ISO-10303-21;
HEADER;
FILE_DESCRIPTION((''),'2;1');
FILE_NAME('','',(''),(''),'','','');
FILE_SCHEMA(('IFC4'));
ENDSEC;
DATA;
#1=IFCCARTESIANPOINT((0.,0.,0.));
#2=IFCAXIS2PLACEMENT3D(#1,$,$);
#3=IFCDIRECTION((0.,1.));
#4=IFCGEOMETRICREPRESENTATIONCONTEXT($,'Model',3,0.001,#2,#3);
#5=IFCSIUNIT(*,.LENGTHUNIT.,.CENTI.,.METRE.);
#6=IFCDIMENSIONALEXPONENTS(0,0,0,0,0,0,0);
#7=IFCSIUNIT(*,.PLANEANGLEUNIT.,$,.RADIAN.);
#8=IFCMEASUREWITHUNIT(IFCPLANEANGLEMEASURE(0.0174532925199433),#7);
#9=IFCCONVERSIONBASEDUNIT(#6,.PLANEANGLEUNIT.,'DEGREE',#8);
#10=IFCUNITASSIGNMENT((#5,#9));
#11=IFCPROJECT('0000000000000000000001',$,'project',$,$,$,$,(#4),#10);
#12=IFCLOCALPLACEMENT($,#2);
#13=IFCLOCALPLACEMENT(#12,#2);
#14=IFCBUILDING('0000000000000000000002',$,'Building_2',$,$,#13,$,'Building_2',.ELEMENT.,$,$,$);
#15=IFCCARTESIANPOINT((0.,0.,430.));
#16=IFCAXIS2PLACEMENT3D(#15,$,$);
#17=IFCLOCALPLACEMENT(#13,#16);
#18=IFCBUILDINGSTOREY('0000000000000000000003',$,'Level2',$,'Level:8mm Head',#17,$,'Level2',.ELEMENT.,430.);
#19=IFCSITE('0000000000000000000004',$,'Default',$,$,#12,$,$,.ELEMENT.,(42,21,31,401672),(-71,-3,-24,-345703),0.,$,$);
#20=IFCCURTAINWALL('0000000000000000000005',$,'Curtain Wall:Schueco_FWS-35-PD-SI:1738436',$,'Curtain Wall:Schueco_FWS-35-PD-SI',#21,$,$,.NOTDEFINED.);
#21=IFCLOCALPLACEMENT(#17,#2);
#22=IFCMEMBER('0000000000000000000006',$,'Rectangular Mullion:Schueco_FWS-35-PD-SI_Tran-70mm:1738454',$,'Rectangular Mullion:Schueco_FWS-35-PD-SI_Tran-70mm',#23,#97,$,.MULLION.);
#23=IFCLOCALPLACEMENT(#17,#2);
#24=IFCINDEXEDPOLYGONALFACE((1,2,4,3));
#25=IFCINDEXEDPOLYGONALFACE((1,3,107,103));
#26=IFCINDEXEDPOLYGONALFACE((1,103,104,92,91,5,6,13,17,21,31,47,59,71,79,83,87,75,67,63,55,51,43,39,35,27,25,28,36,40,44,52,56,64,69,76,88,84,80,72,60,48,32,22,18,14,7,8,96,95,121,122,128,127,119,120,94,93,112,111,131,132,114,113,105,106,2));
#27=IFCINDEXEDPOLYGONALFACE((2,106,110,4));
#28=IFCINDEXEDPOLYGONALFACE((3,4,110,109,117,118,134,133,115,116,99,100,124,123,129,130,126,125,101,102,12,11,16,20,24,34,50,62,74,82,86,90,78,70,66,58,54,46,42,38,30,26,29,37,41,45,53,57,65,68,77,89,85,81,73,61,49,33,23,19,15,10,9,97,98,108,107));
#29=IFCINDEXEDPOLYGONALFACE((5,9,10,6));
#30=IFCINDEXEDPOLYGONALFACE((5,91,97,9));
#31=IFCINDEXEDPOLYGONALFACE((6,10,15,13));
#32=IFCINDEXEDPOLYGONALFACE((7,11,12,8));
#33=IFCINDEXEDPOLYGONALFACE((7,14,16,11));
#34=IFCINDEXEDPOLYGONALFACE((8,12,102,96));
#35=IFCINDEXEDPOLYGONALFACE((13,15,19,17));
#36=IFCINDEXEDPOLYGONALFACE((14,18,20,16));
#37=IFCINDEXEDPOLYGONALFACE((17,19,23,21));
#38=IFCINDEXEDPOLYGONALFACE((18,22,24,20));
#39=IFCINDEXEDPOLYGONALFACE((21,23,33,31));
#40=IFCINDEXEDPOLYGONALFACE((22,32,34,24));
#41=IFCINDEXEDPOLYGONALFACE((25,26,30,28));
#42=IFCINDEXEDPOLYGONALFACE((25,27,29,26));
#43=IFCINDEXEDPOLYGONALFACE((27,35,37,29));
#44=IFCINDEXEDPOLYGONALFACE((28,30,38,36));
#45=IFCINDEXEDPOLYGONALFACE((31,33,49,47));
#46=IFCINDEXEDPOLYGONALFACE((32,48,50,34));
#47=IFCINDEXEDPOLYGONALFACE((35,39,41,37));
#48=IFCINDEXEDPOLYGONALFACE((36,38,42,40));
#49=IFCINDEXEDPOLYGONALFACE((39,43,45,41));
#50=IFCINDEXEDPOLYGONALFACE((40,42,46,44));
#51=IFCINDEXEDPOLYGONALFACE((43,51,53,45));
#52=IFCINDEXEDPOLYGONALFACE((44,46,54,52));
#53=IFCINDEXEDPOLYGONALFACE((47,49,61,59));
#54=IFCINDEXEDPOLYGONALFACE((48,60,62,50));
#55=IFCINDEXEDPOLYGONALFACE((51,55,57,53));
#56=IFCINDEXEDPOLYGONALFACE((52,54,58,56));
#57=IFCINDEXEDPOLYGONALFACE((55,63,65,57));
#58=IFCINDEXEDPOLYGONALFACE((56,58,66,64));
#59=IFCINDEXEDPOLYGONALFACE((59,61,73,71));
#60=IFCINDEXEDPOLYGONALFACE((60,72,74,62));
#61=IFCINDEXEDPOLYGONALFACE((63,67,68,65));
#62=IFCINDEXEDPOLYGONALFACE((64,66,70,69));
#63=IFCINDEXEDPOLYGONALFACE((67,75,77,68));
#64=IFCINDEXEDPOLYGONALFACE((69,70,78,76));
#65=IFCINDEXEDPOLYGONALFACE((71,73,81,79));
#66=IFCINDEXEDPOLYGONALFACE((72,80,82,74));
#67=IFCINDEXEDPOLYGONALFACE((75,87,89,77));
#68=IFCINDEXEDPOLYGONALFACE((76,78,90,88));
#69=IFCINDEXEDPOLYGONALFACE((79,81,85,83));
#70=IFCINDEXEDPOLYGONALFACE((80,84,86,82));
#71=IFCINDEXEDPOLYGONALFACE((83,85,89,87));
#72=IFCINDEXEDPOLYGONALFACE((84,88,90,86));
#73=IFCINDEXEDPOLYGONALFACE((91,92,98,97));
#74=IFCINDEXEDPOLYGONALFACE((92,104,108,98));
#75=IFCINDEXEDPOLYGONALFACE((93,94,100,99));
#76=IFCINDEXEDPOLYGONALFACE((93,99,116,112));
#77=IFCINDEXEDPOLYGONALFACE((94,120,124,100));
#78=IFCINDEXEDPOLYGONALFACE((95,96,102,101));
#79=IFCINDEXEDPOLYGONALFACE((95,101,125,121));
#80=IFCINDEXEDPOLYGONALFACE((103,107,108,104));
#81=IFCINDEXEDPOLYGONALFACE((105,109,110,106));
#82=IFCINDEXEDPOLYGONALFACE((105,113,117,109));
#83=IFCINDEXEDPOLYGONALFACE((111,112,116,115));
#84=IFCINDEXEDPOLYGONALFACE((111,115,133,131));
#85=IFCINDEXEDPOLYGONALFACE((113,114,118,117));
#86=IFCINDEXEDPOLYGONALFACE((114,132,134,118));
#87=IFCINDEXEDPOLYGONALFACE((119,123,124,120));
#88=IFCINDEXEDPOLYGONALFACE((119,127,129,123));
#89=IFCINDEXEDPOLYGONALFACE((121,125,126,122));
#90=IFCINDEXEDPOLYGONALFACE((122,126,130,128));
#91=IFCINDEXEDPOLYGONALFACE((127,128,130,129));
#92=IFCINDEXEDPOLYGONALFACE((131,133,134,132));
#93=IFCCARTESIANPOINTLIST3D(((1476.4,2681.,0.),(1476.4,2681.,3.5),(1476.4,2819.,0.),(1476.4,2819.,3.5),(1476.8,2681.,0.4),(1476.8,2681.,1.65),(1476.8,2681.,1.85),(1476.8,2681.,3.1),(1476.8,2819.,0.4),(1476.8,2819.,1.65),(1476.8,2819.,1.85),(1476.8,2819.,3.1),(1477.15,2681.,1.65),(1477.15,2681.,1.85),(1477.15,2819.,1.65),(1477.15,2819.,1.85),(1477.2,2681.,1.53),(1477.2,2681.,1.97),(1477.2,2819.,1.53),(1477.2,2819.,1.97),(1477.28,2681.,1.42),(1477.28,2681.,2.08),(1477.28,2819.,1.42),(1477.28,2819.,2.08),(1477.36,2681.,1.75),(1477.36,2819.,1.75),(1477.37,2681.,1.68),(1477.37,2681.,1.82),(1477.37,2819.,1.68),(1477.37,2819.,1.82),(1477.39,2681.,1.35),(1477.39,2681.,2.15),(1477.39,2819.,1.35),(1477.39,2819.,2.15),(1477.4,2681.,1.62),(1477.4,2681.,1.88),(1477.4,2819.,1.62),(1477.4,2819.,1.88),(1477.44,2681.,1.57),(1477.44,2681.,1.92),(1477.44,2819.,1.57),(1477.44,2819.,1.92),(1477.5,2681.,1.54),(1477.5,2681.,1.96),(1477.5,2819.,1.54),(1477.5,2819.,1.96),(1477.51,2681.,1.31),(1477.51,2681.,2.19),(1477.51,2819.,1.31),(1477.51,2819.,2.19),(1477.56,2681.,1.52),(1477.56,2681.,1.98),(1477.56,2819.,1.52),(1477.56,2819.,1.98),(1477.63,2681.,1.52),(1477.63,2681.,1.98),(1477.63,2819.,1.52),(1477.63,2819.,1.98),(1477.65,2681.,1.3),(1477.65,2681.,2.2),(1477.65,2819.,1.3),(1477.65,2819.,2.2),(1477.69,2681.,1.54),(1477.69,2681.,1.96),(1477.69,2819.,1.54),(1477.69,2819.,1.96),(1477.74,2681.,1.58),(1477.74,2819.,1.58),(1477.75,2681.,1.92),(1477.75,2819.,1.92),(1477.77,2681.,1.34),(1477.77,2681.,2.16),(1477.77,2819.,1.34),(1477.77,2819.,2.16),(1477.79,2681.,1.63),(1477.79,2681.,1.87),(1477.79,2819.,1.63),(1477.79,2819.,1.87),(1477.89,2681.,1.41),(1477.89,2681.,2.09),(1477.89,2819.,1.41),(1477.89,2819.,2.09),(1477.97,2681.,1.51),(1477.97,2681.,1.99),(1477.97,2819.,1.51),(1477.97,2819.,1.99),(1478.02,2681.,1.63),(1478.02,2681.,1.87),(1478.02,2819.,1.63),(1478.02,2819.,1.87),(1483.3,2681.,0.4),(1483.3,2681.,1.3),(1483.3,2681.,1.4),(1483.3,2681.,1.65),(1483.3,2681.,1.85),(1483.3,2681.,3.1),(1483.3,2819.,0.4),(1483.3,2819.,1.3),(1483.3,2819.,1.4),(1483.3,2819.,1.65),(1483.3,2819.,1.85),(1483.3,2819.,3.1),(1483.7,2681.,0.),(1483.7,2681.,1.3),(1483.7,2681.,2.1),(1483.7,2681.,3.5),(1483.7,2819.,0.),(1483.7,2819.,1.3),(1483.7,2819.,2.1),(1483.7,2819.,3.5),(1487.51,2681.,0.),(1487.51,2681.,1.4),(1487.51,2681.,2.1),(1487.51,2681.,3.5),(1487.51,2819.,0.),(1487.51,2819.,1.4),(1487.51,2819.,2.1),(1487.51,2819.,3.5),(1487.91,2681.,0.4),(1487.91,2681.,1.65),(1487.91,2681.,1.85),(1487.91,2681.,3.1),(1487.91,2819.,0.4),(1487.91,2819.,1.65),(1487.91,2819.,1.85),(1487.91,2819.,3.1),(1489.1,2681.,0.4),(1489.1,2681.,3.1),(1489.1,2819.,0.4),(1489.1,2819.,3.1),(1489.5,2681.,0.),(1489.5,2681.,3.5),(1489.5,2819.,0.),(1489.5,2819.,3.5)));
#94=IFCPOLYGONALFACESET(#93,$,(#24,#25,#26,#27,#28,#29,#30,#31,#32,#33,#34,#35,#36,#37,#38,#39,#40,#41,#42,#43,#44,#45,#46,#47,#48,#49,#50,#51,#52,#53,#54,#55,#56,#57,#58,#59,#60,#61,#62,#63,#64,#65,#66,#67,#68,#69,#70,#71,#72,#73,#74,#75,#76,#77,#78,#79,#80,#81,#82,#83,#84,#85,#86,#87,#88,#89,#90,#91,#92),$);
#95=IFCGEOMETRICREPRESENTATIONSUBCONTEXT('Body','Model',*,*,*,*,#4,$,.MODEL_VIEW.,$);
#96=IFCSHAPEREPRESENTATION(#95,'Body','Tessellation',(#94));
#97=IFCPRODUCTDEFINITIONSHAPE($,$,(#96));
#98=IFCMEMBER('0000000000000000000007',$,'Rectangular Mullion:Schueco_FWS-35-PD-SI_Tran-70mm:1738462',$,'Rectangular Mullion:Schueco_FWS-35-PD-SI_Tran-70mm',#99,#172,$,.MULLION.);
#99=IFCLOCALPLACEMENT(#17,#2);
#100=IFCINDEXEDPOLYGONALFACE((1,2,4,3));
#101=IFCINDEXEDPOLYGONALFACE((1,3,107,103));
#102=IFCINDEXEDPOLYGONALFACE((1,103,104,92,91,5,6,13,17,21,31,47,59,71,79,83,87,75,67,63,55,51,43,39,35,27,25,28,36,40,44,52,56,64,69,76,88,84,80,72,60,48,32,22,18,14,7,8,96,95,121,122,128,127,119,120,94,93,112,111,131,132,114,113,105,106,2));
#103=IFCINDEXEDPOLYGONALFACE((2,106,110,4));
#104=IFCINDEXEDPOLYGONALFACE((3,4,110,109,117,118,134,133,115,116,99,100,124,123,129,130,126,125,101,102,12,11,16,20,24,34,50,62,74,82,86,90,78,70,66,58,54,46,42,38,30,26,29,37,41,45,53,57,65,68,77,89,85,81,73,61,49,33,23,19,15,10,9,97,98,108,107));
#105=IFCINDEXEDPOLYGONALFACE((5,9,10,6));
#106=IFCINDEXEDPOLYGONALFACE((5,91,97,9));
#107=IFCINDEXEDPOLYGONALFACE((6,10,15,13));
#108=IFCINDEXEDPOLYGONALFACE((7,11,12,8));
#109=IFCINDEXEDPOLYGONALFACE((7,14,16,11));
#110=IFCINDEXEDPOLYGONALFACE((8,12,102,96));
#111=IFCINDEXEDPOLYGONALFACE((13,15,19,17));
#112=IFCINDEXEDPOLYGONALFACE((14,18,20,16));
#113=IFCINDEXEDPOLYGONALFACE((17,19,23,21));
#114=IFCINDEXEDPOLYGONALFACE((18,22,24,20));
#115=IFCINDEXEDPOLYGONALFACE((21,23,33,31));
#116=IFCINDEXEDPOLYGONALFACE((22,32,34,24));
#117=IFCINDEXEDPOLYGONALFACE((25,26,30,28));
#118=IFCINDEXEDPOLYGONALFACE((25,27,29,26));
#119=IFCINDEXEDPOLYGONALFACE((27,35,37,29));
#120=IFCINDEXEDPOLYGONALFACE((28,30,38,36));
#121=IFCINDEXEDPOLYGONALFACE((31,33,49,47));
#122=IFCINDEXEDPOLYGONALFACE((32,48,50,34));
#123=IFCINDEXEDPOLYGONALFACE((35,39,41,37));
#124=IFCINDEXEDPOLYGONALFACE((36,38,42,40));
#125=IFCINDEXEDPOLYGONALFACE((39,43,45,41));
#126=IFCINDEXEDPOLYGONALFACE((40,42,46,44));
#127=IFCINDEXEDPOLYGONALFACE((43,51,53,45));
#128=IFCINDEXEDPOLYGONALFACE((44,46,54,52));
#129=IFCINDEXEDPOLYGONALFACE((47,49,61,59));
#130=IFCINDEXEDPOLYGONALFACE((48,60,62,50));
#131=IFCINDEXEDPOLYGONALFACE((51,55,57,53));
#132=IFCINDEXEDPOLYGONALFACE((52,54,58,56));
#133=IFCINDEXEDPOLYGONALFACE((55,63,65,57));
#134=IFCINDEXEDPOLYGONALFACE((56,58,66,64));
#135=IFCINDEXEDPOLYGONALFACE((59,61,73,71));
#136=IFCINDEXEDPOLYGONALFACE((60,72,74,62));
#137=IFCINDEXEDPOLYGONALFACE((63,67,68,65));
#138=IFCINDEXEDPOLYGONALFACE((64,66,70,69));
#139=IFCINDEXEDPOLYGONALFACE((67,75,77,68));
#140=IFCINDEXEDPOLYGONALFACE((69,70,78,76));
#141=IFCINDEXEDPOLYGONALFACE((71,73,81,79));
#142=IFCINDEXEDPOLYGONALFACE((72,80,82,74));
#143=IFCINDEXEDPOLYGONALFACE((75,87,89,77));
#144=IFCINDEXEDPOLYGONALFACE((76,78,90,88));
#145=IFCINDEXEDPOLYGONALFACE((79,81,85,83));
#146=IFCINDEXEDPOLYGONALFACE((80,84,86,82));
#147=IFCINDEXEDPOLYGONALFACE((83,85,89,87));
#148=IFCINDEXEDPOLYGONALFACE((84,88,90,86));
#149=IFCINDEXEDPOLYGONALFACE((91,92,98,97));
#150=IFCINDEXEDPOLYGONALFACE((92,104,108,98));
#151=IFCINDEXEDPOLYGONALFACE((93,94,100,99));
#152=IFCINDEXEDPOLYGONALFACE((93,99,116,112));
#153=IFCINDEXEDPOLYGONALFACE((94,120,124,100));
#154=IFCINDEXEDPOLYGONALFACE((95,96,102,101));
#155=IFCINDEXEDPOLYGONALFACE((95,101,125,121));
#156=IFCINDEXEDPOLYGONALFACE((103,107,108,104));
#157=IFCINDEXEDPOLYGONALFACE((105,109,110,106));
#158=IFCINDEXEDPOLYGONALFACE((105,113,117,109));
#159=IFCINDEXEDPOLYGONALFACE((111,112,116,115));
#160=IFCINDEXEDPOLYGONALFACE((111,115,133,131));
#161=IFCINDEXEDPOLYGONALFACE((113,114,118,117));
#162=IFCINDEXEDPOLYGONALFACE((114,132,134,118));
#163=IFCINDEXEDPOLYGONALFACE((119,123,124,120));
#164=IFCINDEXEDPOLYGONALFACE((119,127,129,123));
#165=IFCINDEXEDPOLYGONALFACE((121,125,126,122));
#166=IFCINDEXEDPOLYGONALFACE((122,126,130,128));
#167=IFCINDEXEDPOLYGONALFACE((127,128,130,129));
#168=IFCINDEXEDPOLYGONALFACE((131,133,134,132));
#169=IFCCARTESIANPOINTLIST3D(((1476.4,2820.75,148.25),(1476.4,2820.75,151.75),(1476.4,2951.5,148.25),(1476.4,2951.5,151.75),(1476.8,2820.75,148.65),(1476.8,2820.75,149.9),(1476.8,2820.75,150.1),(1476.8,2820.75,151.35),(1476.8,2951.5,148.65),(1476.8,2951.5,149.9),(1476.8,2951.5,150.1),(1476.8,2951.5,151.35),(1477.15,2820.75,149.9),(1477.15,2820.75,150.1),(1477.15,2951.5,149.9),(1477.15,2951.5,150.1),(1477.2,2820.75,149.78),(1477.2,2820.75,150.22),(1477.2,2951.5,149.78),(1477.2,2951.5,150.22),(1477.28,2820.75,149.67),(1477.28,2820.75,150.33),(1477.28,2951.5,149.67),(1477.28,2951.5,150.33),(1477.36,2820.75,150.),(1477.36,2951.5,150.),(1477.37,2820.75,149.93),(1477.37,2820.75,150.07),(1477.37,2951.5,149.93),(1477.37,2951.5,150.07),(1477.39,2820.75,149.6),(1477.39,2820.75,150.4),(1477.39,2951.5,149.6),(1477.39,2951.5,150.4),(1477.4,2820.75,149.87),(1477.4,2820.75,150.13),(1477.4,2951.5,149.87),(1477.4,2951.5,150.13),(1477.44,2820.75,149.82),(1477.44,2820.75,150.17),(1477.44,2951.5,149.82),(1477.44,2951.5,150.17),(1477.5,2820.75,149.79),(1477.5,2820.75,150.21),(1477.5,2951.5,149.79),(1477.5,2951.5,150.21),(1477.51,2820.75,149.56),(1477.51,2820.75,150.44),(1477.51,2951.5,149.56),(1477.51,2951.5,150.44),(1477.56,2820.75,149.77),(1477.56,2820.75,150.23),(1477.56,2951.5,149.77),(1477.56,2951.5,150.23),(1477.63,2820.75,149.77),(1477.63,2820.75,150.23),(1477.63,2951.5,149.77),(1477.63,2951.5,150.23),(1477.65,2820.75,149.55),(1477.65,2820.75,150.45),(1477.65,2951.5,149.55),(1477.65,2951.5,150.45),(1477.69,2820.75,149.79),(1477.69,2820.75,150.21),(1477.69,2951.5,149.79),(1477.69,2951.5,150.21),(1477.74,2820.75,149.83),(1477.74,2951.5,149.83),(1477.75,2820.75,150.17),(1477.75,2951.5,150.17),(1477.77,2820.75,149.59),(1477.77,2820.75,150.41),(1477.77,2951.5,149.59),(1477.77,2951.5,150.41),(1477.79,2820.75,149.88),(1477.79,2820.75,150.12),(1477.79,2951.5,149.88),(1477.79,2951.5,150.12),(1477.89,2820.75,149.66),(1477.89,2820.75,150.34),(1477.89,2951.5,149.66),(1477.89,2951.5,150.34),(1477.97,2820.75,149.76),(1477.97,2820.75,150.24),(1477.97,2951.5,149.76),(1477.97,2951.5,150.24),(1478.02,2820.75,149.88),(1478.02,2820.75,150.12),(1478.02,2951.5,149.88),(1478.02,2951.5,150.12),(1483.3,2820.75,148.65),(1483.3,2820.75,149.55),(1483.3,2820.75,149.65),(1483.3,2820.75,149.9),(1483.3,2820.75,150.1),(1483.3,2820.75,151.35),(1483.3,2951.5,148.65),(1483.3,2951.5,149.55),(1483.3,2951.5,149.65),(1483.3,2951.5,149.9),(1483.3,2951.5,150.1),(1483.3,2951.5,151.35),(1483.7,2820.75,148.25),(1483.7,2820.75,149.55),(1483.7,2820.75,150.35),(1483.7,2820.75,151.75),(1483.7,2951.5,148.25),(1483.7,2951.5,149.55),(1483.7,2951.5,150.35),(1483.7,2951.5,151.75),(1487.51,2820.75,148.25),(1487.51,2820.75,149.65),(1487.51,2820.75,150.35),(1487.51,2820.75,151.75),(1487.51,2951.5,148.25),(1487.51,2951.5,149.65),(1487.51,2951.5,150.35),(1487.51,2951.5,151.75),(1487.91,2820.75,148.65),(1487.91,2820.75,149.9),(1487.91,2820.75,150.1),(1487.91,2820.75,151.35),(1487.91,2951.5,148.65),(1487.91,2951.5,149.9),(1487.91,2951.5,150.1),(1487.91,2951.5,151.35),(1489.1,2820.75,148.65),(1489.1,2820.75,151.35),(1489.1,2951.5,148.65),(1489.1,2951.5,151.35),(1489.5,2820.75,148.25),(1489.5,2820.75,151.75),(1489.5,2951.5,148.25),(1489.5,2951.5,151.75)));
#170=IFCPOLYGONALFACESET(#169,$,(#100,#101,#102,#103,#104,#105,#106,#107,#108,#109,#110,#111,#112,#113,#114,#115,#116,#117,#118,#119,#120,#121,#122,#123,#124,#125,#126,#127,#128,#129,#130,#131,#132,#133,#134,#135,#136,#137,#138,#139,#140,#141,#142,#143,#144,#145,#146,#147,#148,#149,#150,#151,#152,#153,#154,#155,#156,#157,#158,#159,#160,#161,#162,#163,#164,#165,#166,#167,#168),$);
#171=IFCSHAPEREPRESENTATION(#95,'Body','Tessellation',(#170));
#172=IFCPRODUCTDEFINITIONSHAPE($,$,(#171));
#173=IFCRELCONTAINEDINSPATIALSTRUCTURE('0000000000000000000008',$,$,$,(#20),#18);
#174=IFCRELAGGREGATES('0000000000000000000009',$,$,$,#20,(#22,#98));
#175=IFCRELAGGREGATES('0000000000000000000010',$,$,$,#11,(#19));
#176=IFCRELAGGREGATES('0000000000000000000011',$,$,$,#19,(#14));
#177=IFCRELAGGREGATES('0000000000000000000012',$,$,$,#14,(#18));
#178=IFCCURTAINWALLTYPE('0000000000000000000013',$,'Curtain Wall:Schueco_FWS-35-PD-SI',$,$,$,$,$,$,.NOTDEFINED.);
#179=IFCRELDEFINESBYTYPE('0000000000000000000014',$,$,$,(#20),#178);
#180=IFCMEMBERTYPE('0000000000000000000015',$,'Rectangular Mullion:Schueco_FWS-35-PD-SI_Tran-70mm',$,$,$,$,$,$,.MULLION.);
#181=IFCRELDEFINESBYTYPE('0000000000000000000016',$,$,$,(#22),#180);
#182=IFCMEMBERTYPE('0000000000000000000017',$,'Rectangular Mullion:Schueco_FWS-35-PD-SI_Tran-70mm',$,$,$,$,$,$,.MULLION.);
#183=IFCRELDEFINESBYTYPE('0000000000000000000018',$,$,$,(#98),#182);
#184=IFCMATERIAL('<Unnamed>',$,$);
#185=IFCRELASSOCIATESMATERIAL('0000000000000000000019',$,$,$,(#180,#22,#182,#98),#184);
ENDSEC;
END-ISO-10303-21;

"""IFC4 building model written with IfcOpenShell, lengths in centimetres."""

from ifc_helpers import new_model, entity, si_unit, converted_unit, direction, frame, origin, place, context, subcontext, project, spatial, line, arc, indexed_curve, outline, extrude, source, transform, mapped, material, type_object, type_shapes, element, aggregate, save


model = new_model("IFC4")

# Units and contexts
model_context = context("Model", 3, precision=0.001, world=origin(), true_north=direction((0.0, 1.0)))
body_context = subcontext(model_context, "Body", "Model", "MODEL_VIEW")
ifc_project = project(units=[si_unit("LENGTHUNIT", "METRE", prefix="CENTI"), converted_unit("PLANEANGLEUNIT", "DEGREE", entity("IfcPlaneAngleMeasure", 0.0174532925199433), si_unit("PLANEANGLEUNIT", "RADIAN"), dimensions=[0, 0, 0, 0, 0, 0, 0])], contexts=[model_context])

# Site, building, storey
site_placement = place(None, origin())
site = spatial("IfcSite", under=ifc_project, at=site_placement, Name="Default", CompositionType="ELEMENT", RefLatitude=(42, 21, 31, 401672), RefLongitude=(-71, -3, -24, -345703), RefElevation=0.0)
building_placement = place(site_placement, origin())
building = spatial("IfcBuilding", under=site, at=building_placement, Name="Building_2", LongName="Building_2", CompositionType="ELEMENT")
storey_placement = place(building_placement, frame((0.0, 0.0, 430.0)))
storey = spatial("IfcBuildingStorey", under=building, at=storey_placement, Name="Level2", ObjectType="Level:8mm Head", LongName="Level2", CompositionType="ELEMENT", Elevation=430.0)

# Curtain wall, members
curtain_wall_type = type_object("IfcCurtainWallType", Name="Curtain Wall:Schueco_FWS-35-PD-SI", PredefinedType="NOTDEFINED")
curtain_wall_placement = place(storey_placement, frame((0.0, 0.0, -430.0)))
curtain_wall = element("IfcCurtainWall", 1, at=curtain_wall_placement, inside=storey, type_object=curtain_wall_type, Name="Curtain Wall:Schueco_FWS-35-PD-SI:1738436", ObjectType="Curtain Wall:Schueco_FWS-35-PD-SI", PredefinedType="NOTDEFINED")
ifc_material_1 = material(Name="<Unnamed>")
member_type_1 = type_object("IfcMemberType", Name="Rectangular Mullion:Schueco_FWS-35-PD-SI_Tran-70mm", PredefinedType="MULLION", material=ifc_material_1)
shared_shape_1 = source(origin(), body_context, "Body", "SweptSolid", [
    extrude(outline(indexed_curve([(-6.52, -1.78), (0.78, -1.78), (0.78, -0.38), (4.59, -0.38), (4.59, -1.78), (6.58, -1.78), (6.58, 1.72), (4.59, 1.72), (4.59, 0.32), (0.38, 0.32), (0.38, 0.07), (4.99, 0.07), (4.99, 1.32), (6.18, 1.32), (6.18, -1.38), (4.99, -1.38), (4.99, -0.13), (0.38, -0.13), (0.38, -1.38), (-6.12, -1.38), (-6.12, -0.13), (-5.77, -0.13), (-5.34, -0.48), (-4.9, -0.15), (-5.14, -0.15), (-5.56, -0.03), (-5.14, 0.09), (-4.9, 0.09), (-5.34, 0.42), (-5.77, 0.07), (-6.12, 0.07), (-6.12, 1.32), (0.38, 1.32), (0.38, 0.42), (0.78, 0.42), (0.78, 1.72), (-6.52, 1.72)], segments=[line(1, 2, 3, 4, 5, 6, 7, 8, 9, 10, 11, 12, 13, 14, 15, 16, 17, 18, 19, 20, 21, 22), arc(22, 23, 24), line(24, 25), arc(25, 26, 27), line(27, 28), arc(28, 29, 30), line(30, 31, 32, 33, 34, 35, 36, 37, 1)], self_intersect=False)), frame((-1.72, 4.58, -138.0), z_axis=(0.0, 0.0, 1.0), x_axis=(0.0, -1.0, 0.0)), (0.0, 0.0, 1.0), 138.0),
])
type_shapes(member_type_1, [shared_shape_1])
member_1_placement = place(curtain_wall_placement, frame((1487.5, 2819.0, 430.0), z_axis=(0.0, 1.0, 0.0), x_axis=(0.0, 0.0, -1.0)))
member_1 = element("IfcMember", 2, at=member_1_placement, type_object=member_type_1, material=ifc_material_1, Name="Rectangular Mullion:Schueco_FWS-35-PD-SI_Tran-70mm:1738454", ObjectType="Rectangular Mullion:Schueco_FWS-35-PD-SI_Tran-70mm", PredefinedType="MULLION", context=body_context, shape_type="MappedRepresentation", body=[
    mapped(shared_shape_1, transform((0.0, 0.0, 0.0), scale=1.0)),
])
member_type_2 = type_object("IfcMemberType", Name="Rectangular Mullion:Schueco_FWS-35-PD-SI_Tran-70mm", PredefinedType="MULLION", material=ifc_material_1)
shared_shape_2 = source(origin(), body_context, "Body", "SweptSolid", [
    extrude(outline(indexed_curve([(-1.78, -6.52), (1.72, -6.52), (1.72, 0.78), (0.42, 0.78), (0.42, 0.38), (1.32, 0.38), (1.32, -6.12), (0.07, -6.12), (0.07, -5.77), (0.42, -5.34), (0.09, -4.9), (0.09, -5.14), (-0.03, -5.56), (-0.15, -5.14), (-0.15, -4.9), (-0.48, -5.34), (-0.13, -5.77), (-0.13, -6.12), (-1.38, -6.12), (-1.38, 0.38), (-0.13, 0.38), (-0.13, 4.99), (-1.38, 4.99), (-1.38, 6.18), (1.32, 6.18), (1.32, 4.99), (0.07, 4.99), (0.07, 0.38), (0.32, 0.38), (0.32, 4.59), (1.72, 4.59), (1.72, 6.58), (-1.78, 6.58), (-1.78, 4.59), (-0.38, 4.59), (-0.38, 0.78), (-1.78, 0.78)], segments=[line(1, 2, 3, 4, 5, 6, 7, 8, 9), arc(9, 10, 11), line(11, 12), arc(12, 13, 14), line(14, 15), arc(15, 16, 17), line(17, 18, 19, 20, 21, 22, 23, 24, 25, 26, 27, 28, 29, 30, 31, 32, 33, 34, 35, 36, 37, 1)], self_intersect=False)), frame((-0.03, 4.58, -130.75), z_axis=(0.0, 0.0, 1.0), x_axis=(-1.0, 0.0, 0.0)), (0.0, 0.0, 1.0), 130.75),
])
type_shapes(member_type_2, [shared_shape_2])
member_2_placement = place(curtain_wall_placement, frame((1487.5, 2820.75, 580.0), z_axis=(0.0, -1.0, 0.0), x_axis=(0.0, 0.0, 1.0)))
member_2 = element("IfcMember", 3, at=member_2_placement, type_object=member_type_2, material=ifc_material_1, Name="Rectangular Mullion:Schueco_FWS-35-PD-SI_Tran-70mm:1738462", ObjectType="Rectangular Mullion:Schueco_FWS-35-PD-SI_Tran-70mm", PredefinedType="MULLION", context=body_context, shape_type="MappedRepresentation", body=[
    mapped(shared_shape_2, transform((0.0, 0.0, 0.0), scale=1.0)),
])
aggregate(curtain_wall, [member_1, member_2])

save(model, "model.ifc")
